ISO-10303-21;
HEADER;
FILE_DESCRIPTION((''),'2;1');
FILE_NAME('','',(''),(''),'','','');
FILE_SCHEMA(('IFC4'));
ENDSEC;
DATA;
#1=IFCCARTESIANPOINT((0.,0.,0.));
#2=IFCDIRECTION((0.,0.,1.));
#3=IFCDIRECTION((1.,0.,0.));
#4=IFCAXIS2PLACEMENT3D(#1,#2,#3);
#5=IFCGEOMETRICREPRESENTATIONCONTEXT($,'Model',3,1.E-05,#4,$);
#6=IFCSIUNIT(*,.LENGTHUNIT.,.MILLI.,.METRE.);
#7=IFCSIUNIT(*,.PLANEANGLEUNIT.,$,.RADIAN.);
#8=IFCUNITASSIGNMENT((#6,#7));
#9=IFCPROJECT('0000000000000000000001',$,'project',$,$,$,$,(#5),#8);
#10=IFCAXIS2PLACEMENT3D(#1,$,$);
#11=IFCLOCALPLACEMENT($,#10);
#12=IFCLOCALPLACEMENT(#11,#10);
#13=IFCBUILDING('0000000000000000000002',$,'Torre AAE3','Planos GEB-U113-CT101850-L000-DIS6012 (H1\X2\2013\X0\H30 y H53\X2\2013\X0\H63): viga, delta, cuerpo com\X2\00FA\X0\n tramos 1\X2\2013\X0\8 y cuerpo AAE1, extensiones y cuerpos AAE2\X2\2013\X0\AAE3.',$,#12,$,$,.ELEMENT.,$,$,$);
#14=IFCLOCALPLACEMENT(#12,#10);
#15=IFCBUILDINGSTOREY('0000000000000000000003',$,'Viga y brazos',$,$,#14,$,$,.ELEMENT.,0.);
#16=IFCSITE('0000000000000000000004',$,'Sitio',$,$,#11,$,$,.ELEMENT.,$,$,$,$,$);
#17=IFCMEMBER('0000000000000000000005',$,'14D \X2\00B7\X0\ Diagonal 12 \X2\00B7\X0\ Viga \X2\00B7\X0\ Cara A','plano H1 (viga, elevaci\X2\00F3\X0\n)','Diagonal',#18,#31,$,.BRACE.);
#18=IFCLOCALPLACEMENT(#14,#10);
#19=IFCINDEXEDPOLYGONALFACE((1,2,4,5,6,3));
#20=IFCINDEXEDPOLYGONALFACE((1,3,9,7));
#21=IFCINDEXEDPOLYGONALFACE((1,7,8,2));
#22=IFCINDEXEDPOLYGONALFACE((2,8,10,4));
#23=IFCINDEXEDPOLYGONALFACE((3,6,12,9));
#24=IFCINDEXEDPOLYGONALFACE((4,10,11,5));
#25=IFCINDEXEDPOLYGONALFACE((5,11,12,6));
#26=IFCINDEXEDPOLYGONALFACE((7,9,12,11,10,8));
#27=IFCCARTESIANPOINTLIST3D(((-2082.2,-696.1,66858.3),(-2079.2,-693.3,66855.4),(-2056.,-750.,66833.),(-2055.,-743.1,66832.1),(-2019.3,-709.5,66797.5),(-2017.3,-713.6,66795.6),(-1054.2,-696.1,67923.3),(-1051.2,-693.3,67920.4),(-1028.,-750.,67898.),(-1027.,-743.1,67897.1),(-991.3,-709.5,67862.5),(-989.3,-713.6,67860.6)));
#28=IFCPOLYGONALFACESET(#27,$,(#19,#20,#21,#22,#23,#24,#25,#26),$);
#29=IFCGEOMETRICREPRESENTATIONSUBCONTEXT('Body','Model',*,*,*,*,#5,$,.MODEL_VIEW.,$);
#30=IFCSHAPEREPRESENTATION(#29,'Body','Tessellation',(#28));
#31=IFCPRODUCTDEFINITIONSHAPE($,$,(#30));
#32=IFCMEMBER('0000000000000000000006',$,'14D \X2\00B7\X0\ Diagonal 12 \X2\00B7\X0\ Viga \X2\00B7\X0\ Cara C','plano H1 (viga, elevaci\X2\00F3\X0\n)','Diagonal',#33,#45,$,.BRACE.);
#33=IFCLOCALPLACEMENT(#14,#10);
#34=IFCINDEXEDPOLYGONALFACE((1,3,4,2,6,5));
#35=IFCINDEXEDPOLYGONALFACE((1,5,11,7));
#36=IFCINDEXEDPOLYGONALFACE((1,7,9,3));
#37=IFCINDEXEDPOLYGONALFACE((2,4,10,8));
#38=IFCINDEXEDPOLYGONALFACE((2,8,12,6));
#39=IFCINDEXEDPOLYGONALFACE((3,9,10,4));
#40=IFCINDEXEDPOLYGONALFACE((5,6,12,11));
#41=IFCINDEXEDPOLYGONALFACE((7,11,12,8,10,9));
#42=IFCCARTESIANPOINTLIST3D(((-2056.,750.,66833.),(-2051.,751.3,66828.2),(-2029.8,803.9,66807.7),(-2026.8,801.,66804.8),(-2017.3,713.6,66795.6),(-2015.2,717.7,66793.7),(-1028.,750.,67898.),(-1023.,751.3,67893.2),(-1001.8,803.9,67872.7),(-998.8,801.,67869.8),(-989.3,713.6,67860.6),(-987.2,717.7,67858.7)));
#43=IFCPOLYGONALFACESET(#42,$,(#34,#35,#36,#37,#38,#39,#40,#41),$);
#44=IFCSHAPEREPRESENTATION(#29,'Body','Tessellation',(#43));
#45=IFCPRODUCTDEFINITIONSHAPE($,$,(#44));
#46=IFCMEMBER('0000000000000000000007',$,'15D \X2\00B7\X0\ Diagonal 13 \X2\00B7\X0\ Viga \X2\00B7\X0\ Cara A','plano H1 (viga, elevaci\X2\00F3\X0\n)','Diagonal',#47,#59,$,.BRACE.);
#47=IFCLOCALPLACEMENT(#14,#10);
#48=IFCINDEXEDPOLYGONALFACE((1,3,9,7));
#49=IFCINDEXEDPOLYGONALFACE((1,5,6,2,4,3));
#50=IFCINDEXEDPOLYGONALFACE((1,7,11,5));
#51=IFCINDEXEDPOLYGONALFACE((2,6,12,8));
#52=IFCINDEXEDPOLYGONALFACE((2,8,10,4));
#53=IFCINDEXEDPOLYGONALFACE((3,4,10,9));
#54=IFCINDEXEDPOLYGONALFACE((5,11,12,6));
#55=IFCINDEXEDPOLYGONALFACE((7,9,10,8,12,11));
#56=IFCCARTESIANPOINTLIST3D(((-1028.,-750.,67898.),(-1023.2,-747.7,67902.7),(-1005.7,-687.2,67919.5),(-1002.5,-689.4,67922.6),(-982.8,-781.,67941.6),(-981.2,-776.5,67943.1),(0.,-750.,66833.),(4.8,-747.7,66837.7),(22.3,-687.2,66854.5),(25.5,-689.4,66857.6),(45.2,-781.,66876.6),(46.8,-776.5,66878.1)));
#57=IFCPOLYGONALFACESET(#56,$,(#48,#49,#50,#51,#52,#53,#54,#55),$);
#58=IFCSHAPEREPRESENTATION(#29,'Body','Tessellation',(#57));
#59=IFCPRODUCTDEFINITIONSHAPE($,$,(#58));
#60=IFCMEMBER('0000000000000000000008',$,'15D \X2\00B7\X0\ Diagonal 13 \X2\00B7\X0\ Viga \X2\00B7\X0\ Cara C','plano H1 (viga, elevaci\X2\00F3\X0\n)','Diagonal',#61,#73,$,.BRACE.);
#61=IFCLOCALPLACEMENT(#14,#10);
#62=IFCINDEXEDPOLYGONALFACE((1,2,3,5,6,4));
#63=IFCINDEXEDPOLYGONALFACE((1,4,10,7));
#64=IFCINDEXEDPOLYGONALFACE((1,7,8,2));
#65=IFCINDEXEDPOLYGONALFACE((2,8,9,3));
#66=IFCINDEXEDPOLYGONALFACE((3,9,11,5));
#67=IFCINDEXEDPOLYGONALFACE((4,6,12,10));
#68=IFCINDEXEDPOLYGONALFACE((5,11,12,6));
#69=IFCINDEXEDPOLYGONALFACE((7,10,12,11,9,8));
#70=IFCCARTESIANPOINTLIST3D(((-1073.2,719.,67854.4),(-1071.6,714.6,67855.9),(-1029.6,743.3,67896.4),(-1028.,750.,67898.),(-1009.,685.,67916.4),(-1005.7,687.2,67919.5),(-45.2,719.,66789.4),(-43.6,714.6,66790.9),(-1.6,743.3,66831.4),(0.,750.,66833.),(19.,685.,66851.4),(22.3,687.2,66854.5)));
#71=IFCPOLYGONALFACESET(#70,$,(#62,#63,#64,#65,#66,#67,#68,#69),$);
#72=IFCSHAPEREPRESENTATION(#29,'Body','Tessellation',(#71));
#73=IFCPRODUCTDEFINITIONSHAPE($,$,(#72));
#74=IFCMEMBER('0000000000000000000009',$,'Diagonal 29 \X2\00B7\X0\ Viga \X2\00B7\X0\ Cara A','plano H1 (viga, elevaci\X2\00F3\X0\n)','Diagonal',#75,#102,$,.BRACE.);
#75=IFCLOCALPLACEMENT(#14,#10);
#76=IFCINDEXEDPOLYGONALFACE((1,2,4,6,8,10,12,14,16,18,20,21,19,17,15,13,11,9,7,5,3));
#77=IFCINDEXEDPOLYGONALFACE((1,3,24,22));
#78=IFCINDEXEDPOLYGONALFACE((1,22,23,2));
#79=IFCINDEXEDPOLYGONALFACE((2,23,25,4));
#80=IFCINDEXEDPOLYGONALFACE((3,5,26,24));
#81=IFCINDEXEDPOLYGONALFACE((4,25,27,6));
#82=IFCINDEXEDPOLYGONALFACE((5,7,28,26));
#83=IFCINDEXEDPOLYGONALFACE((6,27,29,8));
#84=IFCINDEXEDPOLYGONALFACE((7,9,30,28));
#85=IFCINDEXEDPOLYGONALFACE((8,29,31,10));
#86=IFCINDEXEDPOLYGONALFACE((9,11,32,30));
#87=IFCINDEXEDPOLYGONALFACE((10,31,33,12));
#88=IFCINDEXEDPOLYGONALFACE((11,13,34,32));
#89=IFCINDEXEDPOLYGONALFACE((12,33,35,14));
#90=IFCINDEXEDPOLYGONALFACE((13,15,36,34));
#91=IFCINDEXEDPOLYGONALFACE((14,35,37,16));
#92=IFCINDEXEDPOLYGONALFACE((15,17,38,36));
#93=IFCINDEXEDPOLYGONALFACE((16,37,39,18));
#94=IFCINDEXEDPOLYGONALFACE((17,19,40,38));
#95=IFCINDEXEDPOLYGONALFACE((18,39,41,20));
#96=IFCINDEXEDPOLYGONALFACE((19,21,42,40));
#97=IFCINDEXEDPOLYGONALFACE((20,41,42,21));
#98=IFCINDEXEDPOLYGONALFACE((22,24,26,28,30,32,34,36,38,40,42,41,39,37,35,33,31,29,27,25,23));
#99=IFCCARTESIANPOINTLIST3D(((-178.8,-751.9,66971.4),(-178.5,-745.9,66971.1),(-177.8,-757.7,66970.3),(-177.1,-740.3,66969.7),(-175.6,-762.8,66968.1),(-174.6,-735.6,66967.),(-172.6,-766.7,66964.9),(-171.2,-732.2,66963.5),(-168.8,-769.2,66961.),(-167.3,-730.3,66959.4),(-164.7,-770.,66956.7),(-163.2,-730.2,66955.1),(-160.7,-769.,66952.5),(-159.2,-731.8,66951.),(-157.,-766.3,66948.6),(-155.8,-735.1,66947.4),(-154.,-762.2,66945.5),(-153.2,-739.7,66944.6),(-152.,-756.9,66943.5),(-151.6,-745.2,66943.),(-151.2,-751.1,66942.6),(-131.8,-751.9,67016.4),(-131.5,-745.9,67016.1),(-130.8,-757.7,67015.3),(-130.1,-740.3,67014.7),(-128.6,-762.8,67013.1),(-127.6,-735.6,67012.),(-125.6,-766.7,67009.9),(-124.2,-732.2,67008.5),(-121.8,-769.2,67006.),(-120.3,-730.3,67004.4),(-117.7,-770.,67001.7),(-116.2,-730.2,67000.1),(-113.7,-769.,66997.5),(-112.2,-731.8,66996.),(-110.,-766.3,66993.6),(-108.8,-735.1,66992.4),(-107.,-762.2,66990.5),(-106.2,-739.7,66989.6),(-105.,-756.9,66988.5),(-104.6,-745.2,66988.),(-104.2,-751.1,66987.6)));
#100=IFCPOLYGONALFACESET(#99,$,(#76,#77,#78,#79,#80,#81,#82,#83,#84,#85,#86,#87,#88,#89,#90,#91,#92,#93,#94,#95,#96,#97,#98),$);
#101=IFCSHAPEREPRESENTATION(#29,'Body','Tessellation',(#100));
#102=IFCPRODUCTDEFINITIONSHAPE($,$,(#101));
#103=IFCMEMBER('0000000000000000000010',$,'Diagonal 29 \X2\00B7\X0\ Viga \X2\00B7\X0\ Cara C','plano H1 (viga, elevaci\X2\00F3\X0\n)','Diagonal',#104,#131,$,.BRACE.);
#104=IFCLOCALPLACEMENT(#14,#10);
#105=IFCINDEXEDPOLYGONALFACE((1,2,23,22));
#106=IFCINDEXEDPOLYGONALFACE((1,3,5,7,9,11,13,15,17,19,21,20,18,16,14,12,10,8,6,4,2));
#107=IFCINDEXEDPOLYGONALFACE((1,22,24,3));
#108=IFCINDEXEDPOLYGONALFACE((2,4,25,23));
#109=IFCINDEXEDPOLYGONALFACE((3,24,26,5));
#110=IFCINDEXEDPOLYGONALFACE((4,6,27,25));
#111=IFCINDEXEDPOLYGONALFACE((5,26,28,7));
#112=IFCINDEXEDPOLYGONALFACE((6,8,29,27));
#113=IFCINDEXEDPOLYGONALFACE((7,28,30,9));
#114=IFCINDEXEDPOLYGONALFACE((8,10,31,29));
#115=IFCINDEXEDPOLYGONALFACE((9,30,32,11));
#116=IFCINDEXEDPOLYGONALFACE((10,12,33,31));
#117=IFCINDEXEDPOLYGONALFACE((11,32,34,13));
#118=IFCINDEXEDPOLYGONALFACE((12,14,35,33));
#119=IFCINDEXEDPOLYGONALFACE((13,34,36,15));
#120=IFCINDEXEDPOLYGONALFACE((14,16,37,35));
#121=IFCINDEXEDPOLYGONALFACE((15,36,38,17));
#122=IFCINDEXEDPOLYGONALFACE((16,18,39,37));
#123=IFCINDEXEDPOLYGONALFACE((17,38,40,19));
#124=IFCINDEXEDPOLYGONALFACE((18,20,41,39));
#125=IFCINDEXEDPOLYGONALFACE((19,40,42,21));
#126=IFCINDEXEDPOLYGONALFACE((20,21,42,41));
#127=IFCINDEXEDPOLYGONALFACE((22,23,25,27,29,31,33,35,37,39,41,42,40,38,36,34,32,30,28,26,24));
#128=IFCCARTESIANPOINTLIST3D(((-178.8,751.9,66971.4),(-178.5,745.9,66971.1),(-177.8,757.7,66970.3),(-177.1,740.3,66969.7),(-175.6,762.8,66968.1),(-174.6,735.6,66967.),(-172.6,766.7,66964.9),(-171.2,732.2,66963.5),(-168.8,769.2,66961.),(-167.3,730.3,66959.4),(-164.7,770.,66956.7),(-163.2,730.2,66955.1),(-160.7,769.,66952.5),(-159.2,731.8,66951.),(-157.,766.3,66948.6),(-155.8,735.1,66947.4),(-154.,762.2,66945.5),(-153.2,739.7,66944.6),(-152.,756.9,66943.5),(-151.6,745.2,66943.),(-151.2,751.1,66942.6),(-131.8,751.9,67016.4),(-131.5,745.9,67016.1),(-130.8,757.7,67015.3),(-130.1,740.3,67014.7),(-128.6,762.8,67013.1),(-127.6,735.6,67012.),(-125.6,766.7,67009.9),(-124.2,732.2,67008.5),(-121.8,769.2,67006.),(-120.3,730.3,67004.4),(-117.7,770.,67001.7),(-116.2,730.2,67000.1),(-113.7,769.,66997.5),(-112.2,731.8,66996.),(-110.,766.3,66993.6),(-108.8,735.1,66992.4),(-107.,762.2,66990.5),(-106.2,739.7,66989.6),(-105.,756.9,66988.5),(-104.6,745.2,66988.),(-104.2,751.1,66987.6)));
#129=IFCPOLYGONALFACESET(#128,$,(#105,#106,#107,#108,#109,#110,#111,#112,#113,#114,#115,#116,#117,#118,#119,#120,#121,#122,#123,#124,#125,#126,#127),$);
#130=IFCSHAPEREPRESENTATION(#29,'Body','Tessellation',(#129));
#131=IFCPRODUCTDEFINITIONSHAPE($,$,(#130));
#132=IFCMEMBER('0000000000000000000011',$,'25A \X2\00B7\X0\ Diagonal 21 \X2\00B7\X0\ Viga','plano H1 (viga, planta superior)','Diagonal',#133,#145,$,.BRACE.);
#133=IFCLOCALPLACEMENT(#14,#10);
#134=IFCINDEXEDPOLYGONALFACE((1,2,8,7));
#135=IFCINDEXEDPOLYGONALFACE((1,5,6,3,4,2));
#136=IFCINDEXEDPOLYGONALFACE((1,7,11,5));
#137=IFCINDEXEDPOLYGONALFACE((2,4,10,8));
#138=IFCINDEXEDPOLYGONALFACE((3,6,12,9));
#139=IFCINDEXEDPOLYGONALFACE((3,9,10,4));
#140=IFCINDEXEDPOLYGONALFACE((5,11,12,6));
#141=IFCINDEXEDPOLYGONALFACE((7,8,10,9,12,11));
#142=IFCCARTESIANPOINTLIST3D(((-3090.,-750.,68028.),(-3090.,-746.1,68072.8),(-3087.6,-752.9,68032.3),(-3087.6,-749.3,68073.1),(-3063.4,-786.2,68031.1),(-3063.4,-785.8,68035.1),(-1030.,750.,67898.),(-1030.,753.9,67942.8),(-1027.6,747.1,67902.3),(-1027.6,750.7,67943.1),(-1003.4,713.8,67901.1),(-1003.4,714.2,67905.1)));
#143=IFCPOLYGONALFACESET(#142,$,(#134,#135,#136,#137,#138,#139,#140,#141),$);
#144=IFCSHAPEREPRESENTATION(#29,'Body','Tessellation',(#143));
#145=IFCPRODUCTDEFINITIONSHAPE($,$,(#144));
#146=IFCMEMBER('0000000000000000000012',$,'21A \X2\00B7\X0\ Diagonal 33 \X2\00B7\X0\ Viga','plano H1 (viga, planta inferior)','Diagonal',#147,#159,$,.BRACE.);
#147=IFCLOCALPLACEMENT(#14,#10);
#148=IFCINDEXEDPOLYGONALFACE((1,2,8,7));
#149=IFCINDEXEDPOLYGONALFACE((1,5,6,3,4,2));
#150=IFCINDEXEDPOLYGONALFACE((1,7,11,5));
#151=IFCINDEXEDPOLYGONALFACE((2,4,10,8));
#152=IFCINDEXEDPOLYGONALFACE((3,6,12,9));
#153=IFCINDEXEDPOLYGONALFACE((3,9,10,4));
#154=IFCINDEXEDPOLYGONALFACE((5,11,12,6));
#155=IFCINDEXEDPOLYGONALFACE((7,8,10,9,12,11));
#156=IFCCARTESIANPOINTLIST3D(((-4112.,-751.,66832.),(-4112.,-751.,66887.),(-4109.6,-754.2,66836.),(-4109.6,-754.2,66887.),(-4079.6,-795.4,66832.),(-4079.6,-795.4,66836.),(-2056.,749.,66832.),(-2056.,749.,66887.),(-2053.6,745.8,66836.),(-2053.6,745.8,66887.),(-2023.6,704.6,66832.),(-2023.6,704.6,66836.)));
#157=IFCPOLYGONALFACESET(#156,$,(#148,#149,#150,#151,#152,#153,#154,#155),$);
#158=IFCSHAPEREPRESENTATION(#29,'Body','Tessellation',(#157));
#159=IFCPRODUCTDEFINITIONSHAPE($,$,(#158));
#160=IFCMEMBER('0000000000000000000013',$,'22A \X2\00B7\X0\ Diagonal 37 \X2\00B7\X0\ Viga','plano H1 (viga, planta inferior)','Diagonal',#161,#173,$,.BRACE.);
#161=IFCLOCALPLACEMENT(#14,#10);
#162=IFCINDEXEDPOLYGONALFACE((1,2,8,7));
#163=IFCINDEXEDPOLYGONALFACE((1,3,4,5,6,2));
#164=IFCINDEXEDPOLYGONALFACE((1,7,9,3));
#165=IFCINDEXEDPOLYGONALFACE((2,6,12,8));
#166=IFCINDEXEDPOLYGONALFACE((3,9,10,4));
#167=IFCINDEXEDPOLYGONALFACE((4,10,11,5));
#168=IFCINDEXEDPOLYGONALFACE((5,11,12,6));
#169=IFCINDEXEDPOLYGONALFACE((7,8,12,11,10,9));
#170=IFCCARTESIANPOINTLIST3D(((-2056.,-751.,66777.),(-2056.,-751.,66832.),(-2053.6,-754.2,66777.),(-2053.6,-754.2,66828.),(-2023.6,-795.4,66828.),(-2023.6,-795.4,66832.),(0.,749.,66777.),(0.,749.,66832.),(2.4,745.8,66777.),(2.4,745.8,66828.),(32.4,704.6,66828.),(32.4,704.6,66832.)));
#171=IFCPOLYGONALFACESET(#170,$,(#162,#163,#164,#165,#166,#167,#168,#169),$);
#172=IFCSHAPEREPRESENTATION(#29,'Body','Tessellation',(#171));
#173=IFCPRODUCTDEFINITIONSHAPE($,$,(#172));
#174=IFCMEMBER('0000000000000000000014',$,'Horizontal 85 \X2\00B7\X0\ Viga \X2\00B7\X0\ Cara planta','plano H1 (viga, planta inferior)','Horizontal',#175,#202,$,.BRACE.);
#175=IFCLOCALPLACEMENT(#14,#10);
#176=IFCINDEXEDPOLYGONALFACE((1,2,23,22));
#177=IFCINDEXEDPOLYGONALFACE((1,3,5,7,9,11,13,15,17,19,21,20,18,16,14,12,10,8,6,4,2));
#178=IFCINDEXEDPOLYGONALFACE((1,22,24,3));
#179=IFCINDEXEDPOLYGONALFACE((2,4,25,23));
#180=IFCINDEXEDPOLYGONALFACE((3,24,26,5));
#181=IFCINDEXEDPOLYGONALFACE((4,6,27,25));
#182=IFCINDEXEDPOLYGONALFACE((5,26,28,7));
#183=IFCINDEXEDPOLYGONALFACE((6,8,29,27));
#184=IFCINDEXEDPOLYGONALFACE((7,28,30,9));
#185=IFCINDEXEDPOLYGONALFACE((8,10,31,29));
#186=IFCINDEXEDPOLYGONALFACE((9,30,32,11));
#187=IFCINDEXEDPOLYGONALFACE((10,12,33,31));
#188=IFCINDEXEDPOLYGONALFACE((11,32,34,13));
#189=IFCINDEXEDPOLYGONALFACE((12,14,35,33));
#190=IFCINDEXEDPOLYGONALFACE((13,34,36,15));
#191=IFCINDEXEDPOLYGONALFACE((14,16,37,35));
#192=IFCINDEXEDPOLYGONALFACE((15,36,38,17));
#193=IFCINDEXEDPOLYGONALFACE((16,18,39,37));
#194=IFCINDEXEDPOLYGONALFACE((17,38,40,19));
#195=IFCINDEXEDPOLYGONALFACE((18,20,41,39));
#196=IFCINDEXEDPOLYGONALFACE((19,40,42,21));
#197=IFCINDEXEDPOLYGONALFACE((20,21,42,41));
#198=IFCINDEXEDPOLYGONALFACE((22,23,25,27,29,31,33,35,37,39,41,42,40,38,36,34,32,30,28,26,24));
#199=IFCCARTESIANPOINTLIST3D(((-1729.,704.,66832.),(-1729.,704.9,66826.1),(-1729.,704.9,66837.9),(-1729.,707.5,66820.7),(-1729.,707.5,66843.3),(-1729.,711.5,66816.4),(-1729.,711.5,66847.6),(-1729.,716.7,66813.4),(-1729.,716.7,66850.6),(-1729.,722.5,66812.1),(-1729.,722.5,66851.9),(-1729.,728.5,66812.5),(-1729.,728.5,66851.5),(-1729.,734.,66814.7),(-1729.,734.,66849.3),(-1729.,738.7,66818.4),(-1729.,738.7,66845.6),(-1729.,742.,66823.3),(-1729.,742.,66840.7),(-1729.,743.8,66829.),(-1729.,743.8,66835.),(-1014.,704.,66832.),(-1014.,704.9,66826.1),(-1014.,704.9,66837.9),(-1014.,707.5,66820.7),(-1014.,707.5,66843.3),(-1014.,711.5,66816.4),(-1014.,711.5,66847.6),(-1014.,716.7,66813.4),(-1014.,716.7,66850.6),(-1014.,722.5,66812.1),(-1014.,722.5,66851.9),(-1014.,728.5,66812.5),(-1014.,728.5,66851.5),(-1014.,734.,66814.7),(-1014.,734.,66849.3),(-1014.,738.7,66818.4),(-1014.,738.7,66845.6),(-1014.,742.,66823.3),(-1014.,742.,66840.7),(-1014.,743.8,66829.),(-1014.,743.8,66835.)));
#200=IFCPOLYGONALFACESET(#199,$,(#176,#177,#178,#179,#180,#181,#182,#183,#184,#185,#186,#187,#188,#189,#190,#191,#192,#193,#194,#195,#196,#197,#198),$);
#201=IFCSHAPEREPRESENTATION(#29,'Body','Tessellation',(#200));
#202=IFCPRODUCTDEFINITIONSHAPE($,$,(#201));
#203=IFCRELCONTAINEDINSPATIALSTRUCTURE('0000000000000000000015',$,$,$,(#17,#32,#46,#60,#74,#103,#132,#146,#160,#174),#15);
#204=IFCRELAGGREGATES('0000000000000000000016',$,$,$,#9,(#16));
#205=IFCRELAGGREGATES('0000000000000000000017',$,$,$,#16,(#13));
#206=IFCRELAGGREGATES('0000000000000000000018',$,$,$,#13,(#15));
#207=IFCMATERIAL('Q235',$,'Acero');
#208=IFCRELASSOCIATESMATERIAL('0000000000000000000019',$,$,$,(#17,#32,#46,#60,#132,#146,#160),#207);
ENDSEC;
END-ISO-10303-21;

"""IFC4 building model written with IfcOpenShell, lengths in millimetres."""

from ifc_helpers import new_model, si_unit, frame, frame_2d, origin, origin_with_axes, place, context, subcontext, project, spatial, circle, l_section, extrude, material, element, save


model = new_model("IFC4")

# Units and contexts
model_context = context("Model", 3, precision=1e-05, world=origin_with_axes())
body_context = subcontext(model_context, "Body", "Model", "MODEL_VIEW")
ifc_project = project(units=[si_unit("LENGTHUNIT", "METRE", prefix="MILLI"), si_unit("PLANEANGLEUNIT", "RADIAN")], contexts=[model_context])

# Site, building, storey
site_placement = place(None, origin())
site = spatial("IfcSite", under=ifc_project, at=site_placement, Name="Sitio", CompositionType="ELEMENT")
building_placement = place(site_placement, origin())
building = spatial("IfcBuilding", under=site, at=building_placement, Name="Torre AAE3", Description="Planos GEB-U113-CT101850-L000-DIS6012 (H1–H30 y H53–H63): viga, delta, cuerpo común tramos 1–8 y cuerpo AAE1, extensiones y cuerpos AAE2–AAE3.", CompositionType="ELEMENT")
storey_placement = place(building_placement, origin())
storey = spatial("IfcBuildingStorey", under=building, at=storey_placement, Name="Viga y brazos", CompositionType="ELEMENT", Elevation=0.0)

# Members
ifc_material = material(Name="Q235", Category="Acero")
for number, where, z_axis, x_axis, name in (
    (1, (-2056.0, -750.0, 66833.0), (0.694498, 0.0, 0.719495), (0.596074, 0.560044, -0.575366), "14D · Diagonal 12 · Viga · Cara A"),
    (2, (-2056.0, 750.0, 66833.0), (0.694498, 0.0, 0.719495), (0.596074, -0.560044, -0.575366), "14D · Diagonal 12 · Viga · Cara C"),
):
    element("IfcMember", number, at=place(storey_placement, frame(where, z_axis=z_axis, x_axis=x_axis)), inside=storey, material=ifc_material, Name=name, Description="plano H1 (viga, elevación)", ObjectType="Diagonal", PredefinedType="BRACE", context=body_context, shape_type="SweptSolid", body=[
        extrude(l_section(Depth=65.0, Width=65.0, Thickness=5.0, at=frame_2d((32.5, 32.5))), None, (0.0, 0.0, 1.0), 1480.2),
    ])
for number, where, z_axis, x_axis, name in (
    (3, (-1028.0, -750.0, 67898.0), (0.694498, 0.0, -0.719495), (0.318197, 0.896891, 0.307143), "15D · Diagonal 13 · Viga · Cara A"),
    (4, (-1028.0, 750.0, 67898.0), (0.694498, 0.0, -0.719495), (0.318197, -0.896891, 0.307143), "15D · Diagonal 13 · Viga · Cara C"),
):
    element("IfcMember", number, at=place(storey_placement, frame(where, z_axis=z_axis, x_axis=x_axis)), inside=storey, material=ifc_material, Name=name, Description="plano H1 (viga, elevación)", ObjectType="Diagonal", PredefinedType="BRACE", context=body_context, shape_type="SweptSolid", body=[
        extrude(l_section(Depth=70.0, Width=70.0, Thickness=5.0, at=frame_2d((35.0, 35.0))), None, (0.0, 0.0, 1.0), 1480.2),
    ])
for number, where, z_axis, x_axis, name in (
    (5, (-165.0, -750.0, 66957.0), (0.722308, 0.0, 0.691571), (0.089475, 0.991595, -0.093452), "Diagonal 29 · Viga · Cara A"),
    (6, (-165.0, 750.0, 66957.0), (0.722308, 0.0, 0.691571), (0.089475, -0.991595, -0.093452), "Diagonal 29 · Viga · Cara C"),
):
    element("IfcMember", number, at=place(storey_placement, frame(where, z_axis=z_axis, x_axis=x_axis)), inside=storey, Name=name, Description="plano H1 (viga, elevación)", ObjectType="Diagonal", PredefinedType="BRACE", context=body_context, shape_type="SweptSolid", body=[
        extrude(circle(Radius=20.0), None, (0.0, 0.0, 1.0), 65.1),
    ])
member_1_placement = place(storey_placement, frame((-1030.0, 750.0, 67898.0), z_axis=(-0.807347, -0.587874, 0.050949), x_axis=(0.590077, -0.804332, 0.069709)))
element("IfcMember", 7, at=member_1_placement, inside=storey, material=ifc_material, Name="25A · Diagonal 21 · Viga", Description="plano H1 (viga, planta superior)", ObjectType="Diagonal", PredefinedType="BRACE", context=body_context, shape_type="SweptSolid", body=[
    extrude(l_section(Depth=45.0, Width=45.0, Thickness=4.0, at=frame_2d((22.5, 22.5))), None, (0.0, 0.0, 1.0), 2551.6),
])
for number, where, z_axis, x_axis, name in (
    (8, (-2056.0, 749.0, 66832.0), (-0.807852, -0.589386, 0.0), (0.589386, -0.807852, 0.0), "21A · Diagonal 33 · Viga"),
    (9, (-2056.0, -751.0, 66832.0), (0.807852, 0.589386, 0.0), (0.589386, -0.807852, 0.0), "22A · Diagonal 37 · Viga"),
):
    element("IfcMember", number, at=place(storey_placement, frame(where, z_axis=z_axis, x_axis=x_axis)), inside=storey, material=ifc_material, Name=name, Description="plano H1 (viga, planta inferior)", ObjectType="Diagonal", PredefinedType="BRACE", context=body_context, shape_type="SweptSolid", body=[
        extrude(l_section(Depth=55.0, Width=55.0, Thickness=4.0, at=frame_2d((27.5, 27.5))), None, (0.0, 0.0, 1.0), 2545.0),
    ])
member_2_placement = place(storey_placement, frame((-1729.0, 724.0, 66832.0), z_axis=(1.0, 0.0, 0.0), x_axis=(0.0, -1.0, 0.0)))
element("IfcMember", 10, at=member_2_placement, inside=storey, Name="Horizontal 85 · Viga · Cara planta", Description="plano H1 (viga, planta inferior)", ObjectType="Horizontal", PredefinedType="BRACE", context=body_context, shape_type="SweptSolid", body=[
    extrude(circle(Radius=20.0), None, (0.0, 0.0, 1.0), 715.0),
])

save(model, "model.ifc")
